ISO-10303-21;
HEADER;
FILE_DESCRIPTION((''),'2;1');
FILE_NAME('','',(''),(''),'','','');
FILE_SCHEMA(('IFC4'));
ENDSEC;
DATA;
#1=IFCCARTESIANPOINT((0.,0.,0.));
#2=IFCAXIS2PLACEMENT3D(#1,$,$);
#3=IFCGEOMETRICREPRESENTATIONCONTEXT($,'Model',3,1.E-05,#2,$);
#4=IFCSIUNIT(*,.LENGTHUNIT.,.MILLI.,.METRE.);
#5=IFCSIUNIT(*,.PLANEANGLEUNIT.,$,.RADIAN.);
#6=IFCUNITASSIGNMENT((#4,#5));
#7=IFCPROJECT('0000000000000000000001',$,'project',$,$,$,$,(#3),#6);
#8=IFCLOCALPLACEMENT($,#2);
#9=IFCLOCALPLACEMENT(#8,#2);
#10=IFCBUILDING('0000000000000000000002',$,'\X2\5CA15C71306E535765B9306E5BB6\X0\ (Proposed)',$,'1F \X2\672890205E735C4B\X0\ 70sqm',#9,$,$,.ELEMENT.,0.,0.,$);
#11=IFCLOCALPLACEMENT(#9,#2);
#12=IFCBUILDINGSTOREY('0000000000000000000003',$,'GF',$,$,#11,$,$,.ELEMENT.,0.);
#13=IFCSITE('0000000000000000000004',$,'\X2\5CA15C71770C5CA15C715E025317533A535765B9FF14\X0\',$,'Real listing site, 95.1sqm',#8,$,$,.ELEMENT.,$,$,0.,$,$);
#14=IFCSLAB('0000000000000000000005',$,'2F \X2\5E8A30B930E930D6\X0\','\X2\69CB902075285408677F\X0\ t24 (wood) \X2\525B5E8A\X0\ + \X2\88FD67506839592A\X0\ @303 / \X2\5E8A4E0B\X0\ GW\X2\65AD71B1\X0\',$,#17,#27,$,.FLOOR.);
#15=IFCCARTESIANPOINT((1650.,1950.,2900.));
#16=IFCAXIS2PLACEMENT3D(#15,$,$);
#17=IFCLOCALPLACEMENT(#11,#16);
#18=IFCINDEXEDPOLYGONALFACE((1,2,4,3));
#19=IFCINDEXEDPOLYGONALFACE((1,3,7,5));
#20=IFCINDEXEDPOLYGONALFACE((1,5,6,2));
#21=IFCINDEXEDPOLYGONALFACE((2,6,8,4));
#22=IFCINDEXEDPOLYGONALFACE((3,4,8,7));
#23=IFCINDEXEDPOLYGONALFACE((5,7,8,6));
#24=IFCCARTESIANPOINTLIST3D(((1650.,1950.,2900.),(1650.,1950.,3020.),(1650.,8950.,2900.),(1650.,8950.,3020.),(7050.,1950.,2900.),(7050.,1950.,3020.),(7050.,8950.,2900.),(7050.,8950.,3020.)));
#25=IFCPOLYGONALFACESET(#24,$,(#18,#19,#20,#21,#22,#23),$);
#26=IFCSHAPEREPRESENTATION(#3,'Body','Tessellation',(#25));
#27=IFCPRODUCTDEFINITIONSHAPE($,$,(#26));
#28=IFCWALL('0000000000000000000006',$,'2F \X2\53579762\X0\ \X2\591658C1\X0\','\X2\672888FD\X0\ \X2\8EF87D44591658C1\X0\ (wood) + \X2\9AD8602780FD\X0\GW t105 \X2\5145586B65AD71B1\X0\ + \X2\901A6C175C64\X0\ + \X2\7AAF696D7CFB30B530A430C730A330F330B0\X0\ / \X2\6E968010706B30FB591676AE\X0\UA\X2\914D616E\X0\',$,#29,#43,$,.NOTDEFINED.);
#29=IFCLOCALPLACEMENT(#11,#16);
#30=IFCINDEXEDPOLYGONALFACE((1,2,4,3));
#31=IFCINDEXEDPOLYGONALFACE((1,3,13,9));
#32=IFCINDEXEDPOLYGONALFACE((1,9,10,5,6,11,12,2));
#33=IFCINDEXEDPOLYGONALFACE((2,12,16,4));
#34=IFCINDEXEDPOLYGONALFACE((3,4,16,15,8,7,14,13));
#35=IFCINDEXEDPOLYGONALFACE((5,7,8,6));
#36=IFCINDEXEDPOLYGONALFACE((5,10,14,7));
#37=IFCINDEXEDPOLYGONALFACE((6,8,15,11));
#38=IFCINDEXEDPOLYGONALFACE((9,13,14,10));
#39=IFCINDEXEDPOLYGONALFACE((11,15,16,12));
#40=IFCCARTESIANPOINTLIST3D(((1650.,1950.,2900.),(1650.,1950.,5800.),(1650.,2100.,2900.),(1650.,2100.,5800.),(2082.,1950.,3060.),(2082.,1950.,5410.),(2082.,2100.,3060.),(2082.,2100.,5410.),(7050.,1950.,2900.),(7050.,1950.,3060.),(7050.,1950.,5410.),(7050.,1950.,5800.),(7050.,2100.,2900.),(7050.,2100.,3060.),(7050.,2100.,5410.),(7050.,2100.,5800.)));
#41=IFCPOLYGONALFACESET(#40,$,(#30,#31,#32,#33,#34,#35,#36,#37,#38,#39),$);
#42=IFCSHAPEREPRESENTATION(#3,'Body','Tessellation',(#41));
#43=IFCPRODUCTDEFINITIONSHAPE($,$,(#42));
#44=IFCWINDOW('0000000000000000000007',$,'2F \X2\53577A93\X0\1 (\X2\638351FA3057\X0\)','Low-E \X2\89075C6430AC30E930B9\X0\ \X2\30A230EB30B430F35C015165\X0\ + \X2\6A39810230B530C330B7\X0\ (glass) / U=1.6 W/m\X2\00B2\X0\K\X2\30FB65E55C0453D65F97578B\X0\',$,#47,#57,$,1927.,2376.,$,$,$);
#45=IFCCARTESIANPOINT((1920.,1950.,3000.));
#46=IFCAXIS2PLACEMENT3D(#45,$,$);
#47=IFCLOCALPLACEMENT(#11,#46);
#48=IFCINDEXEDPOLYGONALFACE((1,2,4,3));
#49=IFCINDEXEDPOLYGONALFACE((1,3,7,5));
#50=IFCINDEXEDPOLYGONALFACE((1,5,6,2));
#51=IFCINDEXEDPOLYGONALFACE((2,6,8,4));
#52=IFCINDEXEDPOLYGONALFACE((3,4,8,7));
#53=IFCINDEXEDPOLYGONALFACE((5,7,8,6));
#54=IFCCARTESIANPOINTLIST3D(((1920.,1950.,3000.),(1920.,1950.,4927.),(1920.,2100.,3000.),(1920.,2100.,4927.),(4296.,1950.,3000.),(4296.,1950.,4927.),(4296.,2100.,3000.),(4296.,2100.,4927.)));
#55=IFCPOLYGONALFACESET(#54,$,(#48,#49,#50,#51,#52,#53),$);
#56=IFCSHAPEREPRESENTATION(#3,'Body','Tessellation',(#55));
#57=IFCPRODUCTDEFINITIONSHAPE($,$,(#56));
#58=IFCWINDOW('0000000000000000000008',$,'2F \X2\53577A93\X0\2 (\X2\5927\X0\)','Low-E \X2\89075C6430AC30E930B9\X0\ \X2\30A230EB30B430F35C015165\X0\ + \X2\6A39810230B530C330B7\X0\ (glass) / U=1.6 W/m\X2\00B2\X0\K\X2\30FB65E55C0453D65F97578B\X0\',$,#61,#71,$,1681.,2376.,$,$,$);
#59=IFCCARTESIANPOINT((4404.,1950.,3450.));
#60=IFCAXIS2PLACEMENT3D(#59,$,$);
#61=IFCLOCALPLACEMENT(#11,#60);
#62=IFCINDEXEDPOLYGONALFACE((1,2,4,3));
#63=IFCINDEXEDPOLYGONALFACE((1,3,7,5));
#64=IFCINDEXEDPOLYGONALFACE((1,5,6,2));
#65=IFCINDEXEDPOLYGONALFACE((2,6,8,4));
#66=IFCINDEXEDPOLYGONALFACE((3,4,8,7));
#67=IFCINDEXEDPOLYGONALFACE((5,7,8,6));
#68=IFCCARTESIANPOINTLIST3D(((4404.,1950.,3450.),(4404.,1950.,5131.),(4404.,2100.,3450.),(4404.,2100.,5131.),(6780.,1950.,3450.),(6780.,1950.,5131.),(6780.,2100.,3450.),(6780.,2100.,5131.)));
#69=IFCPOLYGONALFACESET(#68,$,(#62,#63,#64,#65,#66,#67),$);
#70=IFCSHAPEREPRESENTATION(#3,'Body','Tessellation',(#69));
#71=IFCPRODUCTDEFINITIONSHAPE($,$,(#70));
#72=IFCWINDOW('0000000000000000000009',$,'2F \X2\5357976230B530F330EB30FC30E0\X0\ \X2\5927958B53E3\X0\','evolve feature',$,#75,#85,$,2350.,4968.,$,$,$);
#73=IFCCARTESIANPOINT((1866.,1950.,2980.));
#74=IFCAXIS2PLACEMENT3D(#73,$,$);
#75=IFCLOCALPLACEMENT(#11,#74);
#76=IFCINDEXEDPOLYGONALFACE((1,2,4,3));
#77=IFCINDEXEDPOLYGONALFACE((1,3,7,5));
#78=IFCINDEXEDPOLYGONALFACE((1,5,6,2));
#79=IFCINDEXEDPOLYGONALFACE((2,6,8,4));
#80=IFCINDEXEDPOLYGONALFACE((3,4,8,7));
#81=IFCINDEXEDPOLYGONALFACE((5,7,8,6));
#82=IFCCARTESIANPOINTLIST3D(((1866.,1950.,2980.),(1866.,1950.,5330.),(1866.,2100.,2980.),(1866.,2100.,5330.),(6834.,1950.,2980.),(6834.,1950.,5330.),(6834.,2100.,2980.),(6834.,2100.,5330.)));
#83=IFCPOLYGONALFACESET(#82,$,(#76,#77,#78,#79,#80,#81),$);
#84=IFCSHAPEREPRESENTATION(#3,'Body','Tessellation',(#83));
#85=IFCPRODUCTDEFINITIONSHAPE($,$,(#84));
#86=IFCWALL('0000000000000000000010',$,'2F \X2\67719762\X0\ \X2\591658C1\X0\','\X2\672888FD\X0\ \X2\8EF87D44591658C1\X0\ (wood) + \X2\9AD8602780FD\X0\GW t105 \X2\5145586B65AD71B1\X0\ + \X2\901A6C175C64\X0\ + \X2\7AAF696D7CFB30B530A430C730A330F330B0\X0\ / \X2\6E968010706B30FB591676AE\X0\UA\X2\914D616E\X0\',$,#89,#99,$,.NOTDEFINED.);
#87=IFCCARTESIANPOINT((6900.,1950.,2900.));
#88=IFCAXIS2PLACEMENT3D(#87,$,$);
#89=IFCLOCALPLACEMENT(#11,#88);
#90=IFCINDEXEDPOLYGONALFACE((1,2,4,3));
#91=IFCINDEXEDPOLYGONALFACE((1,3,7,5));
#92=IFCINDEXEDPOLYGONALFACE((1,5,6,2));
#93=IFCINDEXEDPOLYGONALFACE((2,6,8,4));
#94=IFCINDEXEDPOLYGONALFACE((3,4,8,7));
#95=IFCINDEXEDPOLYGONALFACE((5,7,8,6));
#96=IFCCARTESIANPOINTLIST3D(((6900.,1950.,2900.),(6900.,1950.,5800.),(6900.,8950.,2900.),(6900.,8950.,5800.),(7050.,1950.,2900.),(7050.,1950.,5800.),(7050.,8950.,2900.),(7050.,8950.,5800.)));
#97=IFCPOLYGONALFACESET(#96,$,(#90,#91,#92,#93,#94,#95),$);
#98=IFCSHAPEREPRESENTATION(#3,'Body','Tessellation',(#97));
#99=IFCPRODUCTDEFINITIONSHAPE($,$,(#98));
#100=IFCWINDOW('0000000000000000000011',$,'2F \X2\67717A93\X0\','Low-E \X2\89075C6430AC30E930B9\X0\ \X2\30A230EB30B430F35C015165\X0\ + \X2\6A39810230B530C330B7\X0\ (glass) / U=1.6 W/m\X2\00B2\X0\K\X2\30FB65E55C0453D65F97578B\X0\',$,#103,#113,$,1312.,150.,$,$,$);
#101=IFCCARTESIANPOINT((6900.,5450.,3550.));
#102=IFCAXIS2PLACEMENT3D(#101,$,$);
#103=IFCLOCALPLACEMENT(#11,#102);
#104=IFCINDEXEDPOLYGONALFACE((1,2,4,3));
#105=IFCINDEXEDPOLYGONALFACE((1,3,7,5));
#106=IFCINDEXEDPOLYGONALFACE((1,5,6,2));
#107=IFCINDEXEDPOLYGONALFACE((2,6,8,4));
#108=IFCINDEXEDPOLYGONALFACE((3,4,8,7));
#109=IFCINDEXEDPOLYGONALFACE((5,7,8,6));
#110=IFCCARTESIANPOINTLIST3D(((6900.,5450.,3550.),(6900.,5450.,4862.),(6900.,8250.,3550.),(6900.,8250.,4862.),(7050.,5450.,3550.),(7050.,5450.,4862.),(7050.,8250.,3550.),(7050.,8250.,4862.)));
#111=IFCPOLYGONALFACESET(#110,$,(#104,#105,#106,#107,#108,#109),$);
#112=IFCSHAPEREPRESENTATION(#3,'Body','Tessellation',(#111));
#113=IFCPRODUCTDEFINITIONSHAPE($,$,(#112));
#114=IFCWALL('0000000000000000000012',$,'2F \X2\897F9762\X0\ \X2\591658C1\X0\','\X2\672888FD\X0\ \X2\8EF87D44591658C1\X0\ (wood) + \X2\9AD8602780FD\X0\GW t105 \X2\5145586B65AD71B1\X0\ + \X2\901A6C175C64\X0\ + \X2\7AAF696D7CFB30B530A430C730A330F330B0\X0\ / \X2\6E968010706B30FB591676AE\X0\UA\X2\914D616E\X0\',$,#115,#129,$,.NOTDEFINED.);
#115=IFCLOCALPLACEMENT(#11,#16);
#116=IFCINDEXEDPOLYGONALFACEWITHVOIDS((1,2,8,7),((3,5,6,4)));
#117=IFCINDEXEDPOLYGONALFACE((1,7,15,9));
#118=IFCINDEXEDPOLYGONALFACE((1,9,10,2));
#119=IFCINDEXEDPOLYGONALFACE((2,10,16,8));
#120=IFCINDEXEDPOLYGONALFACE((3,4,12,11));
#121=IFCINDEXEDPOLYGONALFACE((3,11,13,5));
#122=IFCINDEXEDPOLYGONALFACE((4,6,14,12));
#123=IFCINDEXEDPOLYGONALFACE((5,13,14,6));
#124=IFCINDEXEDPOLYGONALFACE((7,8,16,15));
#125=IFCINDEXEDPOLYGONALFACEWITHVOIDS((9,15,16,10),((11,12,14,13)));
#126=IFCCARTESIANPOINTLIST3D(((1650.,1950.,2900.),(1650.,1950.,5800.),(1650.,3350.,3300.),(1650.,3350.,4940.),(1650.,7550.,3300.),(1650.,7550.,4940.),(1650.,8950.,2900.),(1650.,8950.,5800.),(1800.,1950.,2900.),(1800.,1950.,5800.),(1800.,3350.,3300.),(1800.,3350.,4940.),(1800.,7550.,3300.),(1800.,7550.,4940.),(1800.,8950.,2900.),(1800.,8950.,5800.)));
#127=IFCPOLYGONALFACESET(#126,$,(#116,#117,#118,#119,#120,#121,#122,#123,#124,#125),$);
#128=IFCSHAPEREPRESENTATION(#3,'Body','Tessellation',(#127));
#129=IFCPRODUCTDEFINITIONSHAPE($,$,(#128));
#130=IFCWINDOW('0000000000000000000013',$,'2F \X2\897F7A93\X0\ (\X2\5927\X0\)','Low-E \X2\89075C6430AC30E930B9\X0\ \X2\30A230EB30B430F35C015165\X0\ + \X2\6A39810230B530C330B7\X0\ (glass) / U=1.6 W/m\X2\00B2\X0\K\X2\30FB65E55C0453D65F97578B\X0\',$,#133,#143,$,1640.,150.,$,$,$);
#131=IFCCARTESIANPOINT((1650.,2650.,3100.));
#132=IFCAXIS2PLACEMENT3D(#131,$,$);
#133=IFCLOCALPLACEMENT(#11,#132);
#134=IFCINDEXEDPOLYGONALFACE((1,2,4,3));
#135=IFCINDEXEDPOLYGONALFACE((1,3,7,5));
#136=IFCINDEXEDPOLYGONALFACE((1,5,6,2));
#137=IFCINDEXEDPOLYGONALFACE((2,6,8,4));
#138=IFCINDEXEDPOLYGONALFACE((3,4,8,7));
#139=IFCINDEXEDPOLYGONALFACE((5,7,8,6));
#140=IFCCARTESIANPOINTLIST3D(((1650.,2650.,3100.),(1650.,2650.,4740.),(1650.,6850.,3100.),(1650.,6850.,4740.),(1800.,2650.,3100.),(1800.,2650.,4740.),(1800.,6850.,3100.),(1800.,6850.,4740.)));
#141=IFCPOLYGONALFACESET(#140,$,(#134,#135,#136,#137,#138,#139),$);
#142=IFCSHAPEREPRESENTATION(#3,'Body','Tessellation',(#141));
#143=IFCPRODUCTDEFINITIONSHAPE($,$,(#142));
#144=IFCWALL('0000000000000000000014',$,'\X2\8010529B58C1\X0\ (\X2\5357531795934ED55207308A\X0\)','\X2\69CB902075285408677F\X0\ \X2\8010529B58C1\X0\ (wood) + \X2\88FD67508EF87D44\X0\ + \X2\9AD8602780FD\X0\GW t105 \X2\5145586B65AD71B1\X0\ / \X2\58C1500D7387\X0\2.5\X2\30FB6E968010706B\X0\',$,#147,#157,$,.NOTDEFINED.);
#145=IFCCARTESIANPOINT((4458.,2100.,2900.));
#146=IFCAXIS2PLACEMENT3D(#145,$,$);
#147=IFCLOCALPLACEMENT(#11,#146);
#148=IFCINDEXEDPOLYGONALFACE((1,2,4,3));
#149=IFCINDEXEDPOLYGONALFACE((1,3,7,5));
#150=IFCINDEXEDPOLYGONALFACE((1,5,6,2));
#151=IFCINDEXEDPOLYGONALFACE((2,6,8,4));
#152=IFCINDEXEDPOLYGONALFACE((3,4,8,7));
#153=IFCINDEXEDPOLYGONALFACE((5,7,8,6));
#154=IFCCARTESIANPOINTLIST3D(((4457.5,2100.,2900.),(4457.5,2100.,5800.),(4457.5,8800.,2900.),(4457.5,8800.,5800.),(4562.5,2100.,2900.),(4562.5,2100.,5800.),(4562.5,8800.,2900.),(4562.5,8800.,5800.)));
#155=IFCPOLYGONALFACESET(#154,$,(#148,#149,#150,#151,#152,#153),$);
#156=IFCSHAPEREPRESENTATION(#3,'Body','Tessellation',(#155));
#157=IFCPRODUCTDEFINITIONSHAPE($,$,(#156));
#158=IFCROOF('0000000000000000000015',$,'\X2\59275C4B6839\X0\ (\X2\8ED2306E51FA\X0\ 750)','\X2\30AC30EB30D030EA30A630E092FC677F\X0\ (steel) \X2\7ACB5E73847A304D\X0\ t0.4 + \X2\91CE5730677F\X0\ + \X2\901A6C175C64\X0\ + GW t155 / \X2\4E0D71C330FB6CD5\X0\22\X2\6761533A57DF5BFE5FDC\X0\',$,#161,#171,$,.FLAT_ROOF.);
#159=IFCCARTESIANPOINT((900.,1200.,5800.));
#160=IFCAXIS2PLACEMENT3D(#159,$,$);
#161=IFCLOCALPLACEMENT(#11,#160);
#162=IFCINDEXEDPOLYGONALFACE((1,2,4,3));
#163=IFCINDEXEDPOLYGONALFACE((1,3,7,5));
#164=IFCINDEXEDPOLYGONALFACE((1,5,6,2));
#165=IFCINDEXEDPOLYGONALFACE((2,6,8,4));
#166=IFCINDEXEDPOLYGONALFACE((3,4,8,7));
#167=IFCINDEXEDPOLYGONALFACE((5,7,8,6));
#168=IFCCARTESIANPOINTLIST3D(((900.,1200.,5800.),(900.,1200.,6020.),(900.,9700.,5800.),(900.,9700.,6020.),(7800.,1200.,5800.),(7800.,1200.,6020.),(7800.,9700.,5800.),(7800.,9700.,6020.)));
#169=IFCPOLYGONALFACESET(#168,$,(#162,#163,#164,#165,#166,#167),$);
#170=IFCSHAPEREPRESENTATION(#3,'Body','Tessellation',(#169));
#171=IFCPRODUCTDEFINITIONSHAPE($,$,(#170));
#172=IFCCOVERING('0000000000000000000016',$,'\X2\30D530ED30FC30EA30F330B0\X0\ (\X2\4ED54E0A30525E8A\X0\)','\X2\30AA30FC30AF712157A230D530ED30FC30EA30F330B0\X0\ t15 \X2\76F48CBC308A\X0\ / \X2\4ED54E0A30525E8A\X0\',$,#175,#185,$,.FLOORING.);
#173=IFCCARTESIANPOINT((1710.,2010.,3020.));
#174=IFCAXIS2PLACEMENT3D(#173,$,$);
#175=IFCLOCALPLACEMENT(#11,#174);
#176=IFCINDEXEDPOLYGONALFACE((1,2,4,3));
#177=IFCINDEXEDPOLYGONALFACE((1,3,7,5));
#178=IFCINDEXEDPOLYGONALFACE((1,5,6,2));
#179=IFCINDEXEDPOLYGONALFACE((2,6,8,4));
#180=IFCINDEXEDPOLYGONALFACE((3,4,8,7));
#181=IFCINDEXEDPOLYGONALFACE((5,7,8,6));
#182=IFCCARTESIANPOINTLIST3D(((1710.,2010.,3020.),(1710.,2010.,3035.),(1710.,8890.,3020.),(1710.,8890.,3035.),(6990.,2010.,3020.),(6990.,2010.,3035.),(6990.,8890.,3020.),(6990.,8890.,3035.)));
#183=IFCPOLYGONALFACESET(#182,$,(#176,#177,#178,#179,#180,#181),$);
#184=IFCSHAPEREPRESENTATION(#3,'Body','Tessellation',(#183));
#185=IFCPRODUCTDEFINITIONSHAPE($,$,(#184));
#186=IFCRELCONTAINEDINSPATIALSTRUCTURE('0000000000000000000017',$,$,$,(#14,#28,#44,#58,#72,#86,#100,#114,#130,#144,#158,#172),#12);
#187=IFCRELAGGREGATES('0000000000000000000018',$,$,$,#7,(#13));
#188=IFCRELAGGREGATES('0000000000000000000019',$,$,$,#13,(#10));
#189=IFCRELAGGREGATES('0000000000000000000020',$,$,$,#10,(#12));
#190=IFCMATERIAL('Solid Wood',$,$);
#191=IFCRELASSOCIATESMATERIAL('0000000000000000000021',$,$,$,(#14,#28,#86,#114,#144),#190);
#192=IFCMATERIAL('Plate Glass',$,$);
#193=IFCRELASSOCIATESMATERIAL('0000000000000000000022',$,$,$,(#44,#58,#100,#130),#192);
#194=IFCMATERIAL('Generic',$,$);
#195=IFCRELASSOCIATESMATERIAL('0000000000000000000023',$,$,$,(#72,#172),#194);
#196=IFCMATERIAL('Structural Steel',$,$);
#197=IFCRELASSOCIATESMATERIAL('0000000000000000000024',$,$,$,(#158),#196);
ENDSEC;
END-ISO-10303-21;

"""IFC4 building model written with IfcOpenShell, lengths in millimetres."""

from ifc_helpers import new_model, si_unit, frame, frame_2d, origin, place, context, project, spatial, rectangle, extrude, material, element, fill, save


model = new_model("IFC4")

# Units and contexts
model_context = context("Model", 3, precision=1e-05, world=origin())
ifc_project = project(units=[si_unit("LENGTHUNIT", "METRE", prefix="MILLI"), si_unit("PLANEANGLEUNIT", "RADIAN")], contexts=[model_context])

# Site, building, storey
site_placement = place(None, origin())
site = spatial("IfcSite", under=ifc_project, at=site_placement, Name="岡山県岡山市北区南方４", ObjectType="Real listing site, 95.1sqm", CompositionType="ELEMENT", RefElevation=0.0)
building_placement = place(site_placement, origin())
building = spatial("IfcBuilding", under=site, at=building_placement, Name="岡山の南方の家 (Proposed)", ObjectType="1F 木造平屋 70sqm", CompositionType="ELEMENT", ElevationOfRefHeight=0.0, ElevationOfTerrain=0.0)
storey_placement = place(building_placement, origin())
storey = spatial("IfcBuildingStorey", under=building, at=storey_placement, Name="GF", CompositionType="ELEMENT", Elevation=0.0)

# Slab
ifc_material_1 = material(Name="Solid Wood")
slab_placement = place(storey_placement, frame((1650.0, 1950.0, 2900.0)))
element("IfcSlab", 1, at=slab_placement, inside=storey, material=ifc_material_1, Name="2F 床スラブ", Description="構造用合板 t24 (wood) 剛床 + 製材根太 @303 / 床下 GW断熱", PredefinedType="FLOOR", context=model_context, shape_type="SweptSolid", body=[
    extrude(rectangle(XDim=5400.0, YDim=7000.0, at=frame_2d((2700.0, 3500.0))), frame((1650.0, 1950.0, 2900.0)), (0.0, 0.0, 1.0), 120.0),
])

# Wall, openings, windows
wall_1_placement = place(storey_placement, frame((1650.0, 1950.0, 2900.0)))
wall_1 = element("IfcWall", 2, at=wall_1_placement, inside=storey, material=ifc_material_1, Name="2F 南面 外壁", Description="木製 軸組外壁 (wood) + 高性能GW t105 充填断熱 + 通気層 + 窯業系サイディング / 準耐火・外皮UA配慮", PredefinedType="NOTDEFINED", context=model_context, shape_type="SweptSolid", body=[
    extrude(rectangle(XDim=5400.0, YDim=150.0, at=frame_2d((2700.0, 75.0))), frame((1650.0, 1950.0, 2900.0)), (0.0, 0.0, 1.0), 2900.0),
])
opening_1_placement = place(storey_placement, frame((1920.0, 1950.0, 3000.0)))
opening_1 = element("IfcOpeningElement", 3, at=opening_1_placement, cuts=wall_1, PredefinedType="NOTDEFINED", context=model_context, shape_type="SweptSolid", body=[
    extrude(rectangle(XDim=2376.0, YDim=150.0, at=frame_2d((1188.0, 75.0))), frame((1920.0, 1950.0, 3000.0)), (0.0, 0.0, 1.0), 1927.0),
])
opening_2_placement = place(storey_placement, frame((4404.0, 1950.0, 3450.0)))
opening_2 = element("IfcOpeningElement", 4, at=opening_2_placement, cuts=wall_1, PredefinedType="NOTDEFINED", context=model_context, shape_type="SweptSolid", body=[
    extrude(rectangle(XDim=2376.0, YDim=150.0, at=frame_2d((1188.0, 75.0))), frame((4404.0, 1950.0, 3450.0)), (0.0, 0.0, 1.0), 1681.0),
])
opening_3_placement = place(storey_placement, frame((1866.0, 1950.0, 2980.0)))
opening_3 = element("IfcOpeningElement", 5, at=opening_3_placement, cuts=wall_1, PredefinedType="NOTDEFINED", context=model_context, shape_type="SweptSolid", body=[
    extrude(rectangle(XDim=4968.0, YDim=150.0, at=frame_2d((2484.0, 75.0))), frame((1866.0, 1950.0, 2980.0)), (0.0, 0.0, 1.0), 2350.0),
])
ifc_material_2 = material(Name="Plate Glass")
window_1_placement = place(storey_placement, frame((1920.0, 1950.0, 3000.0)))
window_1 = element("IfcWindow", 6, at=window_1_placement, inside=storey, material=ifc_material_2, Name="2F 南窓1 (掃出し)", Description="Low-E 複層ガラス アルゴン封入 + 樹脂サッシ (glass) / U=1.6 W/m²K・日射取得型", OverallHeight=1927.0, OverallWidth=2376.0, context=model_context, shape_type="SweptSolid", body=[
    extrude(rectangle(XDim=2376.0, YDim=150.0, at=frame_2d((1188.0, 75.0))), frame((1920.0, 1950.0, 3000.0)), (0.0, 0.0, 1.0), 1927.0),
])
fill(opening_1, window_1)
window_2_placement = place(storey_placement, frame((4404.0, 1950.0, 3450.0)))
window_2 = element("IfcWindow", 7, at=window_2_placement, inside=storey, material=ifc_material_2, Name="2F 南窓2 (大)", Description="Low-E 複層ガラス アルゴン封入 + 樹脂サッシ (glass) / U=1.6 W/m²K・日射取得型", OverallHeight=1681.0, OverallWidth=2376.0, context=model_context, shape_type="SweptSolid", body=[
    extrude(rectangle(XDim=2376.0, YDim=150.0, at=frame_2d((1188.0, 75.0))), frame((4404.0, 1950.0, 3450.0)), (0.0, 0.0, 1.0), 1681.0),
])
fill(opening_2, window_2)
ifc_material_3 = material(Name="Generic")
window_3_placement = place(storey_placement, frame((1866.0, 1950.0, 2980.0)))
window_3 = element("IfcWindow", 8, at=window_3_placement, inside=storey, material=ifc_material_3, Name="2F 南面サンルーム 大開口", Description="evolve feature", OverallHeight=2350.0, OverallWidth=4968.0, context=model_context, shape_type="SweptSolid", body=[
    extrude(rectangle(XDim=4968.0, YDim=150.0, at=frame_2d((2484.0, 75.0))), frame((1866.0, 1950.0, 2980.0)), (0.0, 0.0, 1.0), 2350.0),
])
fill(opening_3, window_3)

# Walls, openings, windows
wall_2_placement = place(storey_placement, frame((6900.0, 1950.0, 2900.0)))
wall_2 = element("IfcWall", 9, at=wall_2_placement, inside=storey, material=ifc_material_1, Name="2F 東面 外壁", Description="木製 軸組外壁 (wood) + 高性能GW t105 充填断熱 + 通気層 + 窯業系サイディング / 準耐火・外皮UA配慮", PredefinedType="NOTDEFINED", context=model_context, shape_type="SweptSolid", body=[
    extrude(rectangle(XDim=150.0, YDim=7000.0, at=frame_2d((75.0, 3500.0))), frame((6900.0, 1950.0, 2900.0)), (0.0, 0.0, 1.0), 2900.0),
])
opening_4_placement = place(storey_placement, frame((6900.0, 5450.0, 3550.0)))
opening_4 = element("IfcOpeningElement", 10, at=opening_4_placement, cuts=wall_2, PredefinedType="NOTDEFINED", context=model_context, shape_type="SweptSolid", body=[
    extrude(rectangle(XDim=150.0, YDim=2800.0, at=frame_2d((75.0, 1400.0))), frame((6900.0, 5450.0, 3550.0)), (0.0, 0.0, 1.0), 1312.0),
])
window_4_placement = place(storey_placement, frame((6900.0, 5450.0, 3550.0)))
window_4 = element("IfcWindow", 11, at=window_4_placement, inside=storey, material=ifc_material_2, Name="2F 東窓", Description="Low-E 複層ガラス アルゴン封入 + 樹脂サッシ (glass) / U=1.6 W/m²K・日射取得型", OverallHeight=1312.0, OverallWidth=150.0, context=model_context, shape_type="SweptSolid", body=[
    extrude(rectangle(XDim=150.0, YDim=2800.0, at=frame_2d((75.0, 1400.0))), frame((6900.0, 5450.0, 3550.0)), (0.0, 0.0, 1.0), 1312.0),
])
fill(opening_4, window_4)
wall_3_placement = place(storey_placement, frame((1650.0, 1950.0, 2900.0)))
wall_3 = element("IfcWall", 12, at=wall_3_placement, inside=storey, material=ifc_material_1, Name="2F 西面 外壁", Description="木製 軸組外壁 (wood) + 高性能GW t105 充填断熱 + 通気層 + 窯業系サイディング / 準耐火・外皮UA配慮", PredefinedType="NOTDEFINED", context=model_context, shape_type="SweptSolid", body=[
    extrude(rectangle(XDim=150.0, YDim=7000.0, at=frame_2d((75.0, 3500.0))), frame((1650.0, 1950.0, 2900.0)), (0.0, 0.0, 1.0), 2900.0),
])
opening_5_placement = place(storey_placement, frame((1650.0, 2650.0, 3100.0)))
opening_5 = element("IfcOpeningElement", 13, at=opening_5_placement, cuts=wall_3, PredefinedType="NOTDEFINED", context=model_context, shape_type="SweptSolid", body=[
    extrude(rectangle(XDim=150.0, YDim=4200.0, at=frame_2d((75.0, 2100.0))), frame((1650.0, 2650.0, 3100.0)), (0.0, 0.0, 1.0), 1640.0),
])
window_5_placement = place(storey_placement, frame((1650.0, 2650.0, 3100.0)))
window_5 = element("IfcWindow", 14, at=window_5_placement, inside=storey, material=ifc_material_2, Name="2F 西窓 (大)", Description="Low-E 複層ガラス アルゴン封入 + 樹脂サッシ (glass) / U=1.6 W/m²K・日射取得型", OverallHeight=1640.0, OverallWidth=150.0, context=model_context, shape_type="SweptSolid", body=[
    extrude(rectangle(XDim=150.0, YDim=4200.0, at=frame_2d((75.0, 2100.0))), frame((1650.0, 2650.0, 3100.0)), (0.0, 0.0, 1.0), 1640.0),
])
fill(opening_5, window_5)

# Wall
wall_4_placement = place(storey_placement, frame((4458.0, 2100.0, 2900.0)))
element("IfcWall", 15, at=wall_4_placement, inside=storey, material=ifc_material_1, Name="耐力壁 (南北間仕切り)", Description="構造用合板 耐力壁 (wood) + 製材軸組 + 高性能GW t105 充填断熱 / 壁倍率2.5・準耐火", PredefinedType="NOTDEFINED", context=model_context, shape_type="SweptSolid", body=[
    extrude(rectangle(XDim=105.0, YDim=6700.0, at=frame_2d((52.0, 3350.0))), frame((4458.0, 2100.0, 2900.0)), (0.0, 0.0, 1.0), 2900.0),
])

# Roof
ifc_material_4 = material(Name="Structural Steel")
roof_placement = place(storey_placement, frame((900.0, 1200.0, 5800.0)))
element("IfcRoof", 16, at=roof_placement, inside=storey, material=ifc_material_4, Name="大屋根 (軒の出 750)", Description="ガルバリウム鋼板 (steel) 立平葺き t0.4 + 野地板 + 通気層 + GW t155 / 不燃・法22条区域対応", PredefinedType="FLAT_ROOF", context=model_context, shape_type="SweptSolid", body=[
    extrude(rectangle(XDim=6900.0, YDim=8500.0, at=frame_2d((3450.0, 4250.0))), frame((900.0, 1200.0, 5800.0)), (0.0, 0.0, 1.0), 220.0),
])

# Covering
covering_placement = place(storey_placement, frame((1710.0, 2010.0, 3020.0)))
element("IfcCovering", 17, at=covering_placement, inside=storey, material=ifc_material_3, Name="フローリング (仕上げ床)", Description="オーク無垢フローリング t15 直貼り / 仕上げ床", PredefinedType="FLOORING", context=model_context, shape_type="SweptSolid", body=[
    extrude(rectangle(XDim=5280.0, YDim=6880.0, at=frame_2d((2640.0, 3440.0))), frame((1710.0, 2010.0, 3020.0)), (0.0, 0.0, 1.0), 15.0),
])

save(model, "model.ifc")
